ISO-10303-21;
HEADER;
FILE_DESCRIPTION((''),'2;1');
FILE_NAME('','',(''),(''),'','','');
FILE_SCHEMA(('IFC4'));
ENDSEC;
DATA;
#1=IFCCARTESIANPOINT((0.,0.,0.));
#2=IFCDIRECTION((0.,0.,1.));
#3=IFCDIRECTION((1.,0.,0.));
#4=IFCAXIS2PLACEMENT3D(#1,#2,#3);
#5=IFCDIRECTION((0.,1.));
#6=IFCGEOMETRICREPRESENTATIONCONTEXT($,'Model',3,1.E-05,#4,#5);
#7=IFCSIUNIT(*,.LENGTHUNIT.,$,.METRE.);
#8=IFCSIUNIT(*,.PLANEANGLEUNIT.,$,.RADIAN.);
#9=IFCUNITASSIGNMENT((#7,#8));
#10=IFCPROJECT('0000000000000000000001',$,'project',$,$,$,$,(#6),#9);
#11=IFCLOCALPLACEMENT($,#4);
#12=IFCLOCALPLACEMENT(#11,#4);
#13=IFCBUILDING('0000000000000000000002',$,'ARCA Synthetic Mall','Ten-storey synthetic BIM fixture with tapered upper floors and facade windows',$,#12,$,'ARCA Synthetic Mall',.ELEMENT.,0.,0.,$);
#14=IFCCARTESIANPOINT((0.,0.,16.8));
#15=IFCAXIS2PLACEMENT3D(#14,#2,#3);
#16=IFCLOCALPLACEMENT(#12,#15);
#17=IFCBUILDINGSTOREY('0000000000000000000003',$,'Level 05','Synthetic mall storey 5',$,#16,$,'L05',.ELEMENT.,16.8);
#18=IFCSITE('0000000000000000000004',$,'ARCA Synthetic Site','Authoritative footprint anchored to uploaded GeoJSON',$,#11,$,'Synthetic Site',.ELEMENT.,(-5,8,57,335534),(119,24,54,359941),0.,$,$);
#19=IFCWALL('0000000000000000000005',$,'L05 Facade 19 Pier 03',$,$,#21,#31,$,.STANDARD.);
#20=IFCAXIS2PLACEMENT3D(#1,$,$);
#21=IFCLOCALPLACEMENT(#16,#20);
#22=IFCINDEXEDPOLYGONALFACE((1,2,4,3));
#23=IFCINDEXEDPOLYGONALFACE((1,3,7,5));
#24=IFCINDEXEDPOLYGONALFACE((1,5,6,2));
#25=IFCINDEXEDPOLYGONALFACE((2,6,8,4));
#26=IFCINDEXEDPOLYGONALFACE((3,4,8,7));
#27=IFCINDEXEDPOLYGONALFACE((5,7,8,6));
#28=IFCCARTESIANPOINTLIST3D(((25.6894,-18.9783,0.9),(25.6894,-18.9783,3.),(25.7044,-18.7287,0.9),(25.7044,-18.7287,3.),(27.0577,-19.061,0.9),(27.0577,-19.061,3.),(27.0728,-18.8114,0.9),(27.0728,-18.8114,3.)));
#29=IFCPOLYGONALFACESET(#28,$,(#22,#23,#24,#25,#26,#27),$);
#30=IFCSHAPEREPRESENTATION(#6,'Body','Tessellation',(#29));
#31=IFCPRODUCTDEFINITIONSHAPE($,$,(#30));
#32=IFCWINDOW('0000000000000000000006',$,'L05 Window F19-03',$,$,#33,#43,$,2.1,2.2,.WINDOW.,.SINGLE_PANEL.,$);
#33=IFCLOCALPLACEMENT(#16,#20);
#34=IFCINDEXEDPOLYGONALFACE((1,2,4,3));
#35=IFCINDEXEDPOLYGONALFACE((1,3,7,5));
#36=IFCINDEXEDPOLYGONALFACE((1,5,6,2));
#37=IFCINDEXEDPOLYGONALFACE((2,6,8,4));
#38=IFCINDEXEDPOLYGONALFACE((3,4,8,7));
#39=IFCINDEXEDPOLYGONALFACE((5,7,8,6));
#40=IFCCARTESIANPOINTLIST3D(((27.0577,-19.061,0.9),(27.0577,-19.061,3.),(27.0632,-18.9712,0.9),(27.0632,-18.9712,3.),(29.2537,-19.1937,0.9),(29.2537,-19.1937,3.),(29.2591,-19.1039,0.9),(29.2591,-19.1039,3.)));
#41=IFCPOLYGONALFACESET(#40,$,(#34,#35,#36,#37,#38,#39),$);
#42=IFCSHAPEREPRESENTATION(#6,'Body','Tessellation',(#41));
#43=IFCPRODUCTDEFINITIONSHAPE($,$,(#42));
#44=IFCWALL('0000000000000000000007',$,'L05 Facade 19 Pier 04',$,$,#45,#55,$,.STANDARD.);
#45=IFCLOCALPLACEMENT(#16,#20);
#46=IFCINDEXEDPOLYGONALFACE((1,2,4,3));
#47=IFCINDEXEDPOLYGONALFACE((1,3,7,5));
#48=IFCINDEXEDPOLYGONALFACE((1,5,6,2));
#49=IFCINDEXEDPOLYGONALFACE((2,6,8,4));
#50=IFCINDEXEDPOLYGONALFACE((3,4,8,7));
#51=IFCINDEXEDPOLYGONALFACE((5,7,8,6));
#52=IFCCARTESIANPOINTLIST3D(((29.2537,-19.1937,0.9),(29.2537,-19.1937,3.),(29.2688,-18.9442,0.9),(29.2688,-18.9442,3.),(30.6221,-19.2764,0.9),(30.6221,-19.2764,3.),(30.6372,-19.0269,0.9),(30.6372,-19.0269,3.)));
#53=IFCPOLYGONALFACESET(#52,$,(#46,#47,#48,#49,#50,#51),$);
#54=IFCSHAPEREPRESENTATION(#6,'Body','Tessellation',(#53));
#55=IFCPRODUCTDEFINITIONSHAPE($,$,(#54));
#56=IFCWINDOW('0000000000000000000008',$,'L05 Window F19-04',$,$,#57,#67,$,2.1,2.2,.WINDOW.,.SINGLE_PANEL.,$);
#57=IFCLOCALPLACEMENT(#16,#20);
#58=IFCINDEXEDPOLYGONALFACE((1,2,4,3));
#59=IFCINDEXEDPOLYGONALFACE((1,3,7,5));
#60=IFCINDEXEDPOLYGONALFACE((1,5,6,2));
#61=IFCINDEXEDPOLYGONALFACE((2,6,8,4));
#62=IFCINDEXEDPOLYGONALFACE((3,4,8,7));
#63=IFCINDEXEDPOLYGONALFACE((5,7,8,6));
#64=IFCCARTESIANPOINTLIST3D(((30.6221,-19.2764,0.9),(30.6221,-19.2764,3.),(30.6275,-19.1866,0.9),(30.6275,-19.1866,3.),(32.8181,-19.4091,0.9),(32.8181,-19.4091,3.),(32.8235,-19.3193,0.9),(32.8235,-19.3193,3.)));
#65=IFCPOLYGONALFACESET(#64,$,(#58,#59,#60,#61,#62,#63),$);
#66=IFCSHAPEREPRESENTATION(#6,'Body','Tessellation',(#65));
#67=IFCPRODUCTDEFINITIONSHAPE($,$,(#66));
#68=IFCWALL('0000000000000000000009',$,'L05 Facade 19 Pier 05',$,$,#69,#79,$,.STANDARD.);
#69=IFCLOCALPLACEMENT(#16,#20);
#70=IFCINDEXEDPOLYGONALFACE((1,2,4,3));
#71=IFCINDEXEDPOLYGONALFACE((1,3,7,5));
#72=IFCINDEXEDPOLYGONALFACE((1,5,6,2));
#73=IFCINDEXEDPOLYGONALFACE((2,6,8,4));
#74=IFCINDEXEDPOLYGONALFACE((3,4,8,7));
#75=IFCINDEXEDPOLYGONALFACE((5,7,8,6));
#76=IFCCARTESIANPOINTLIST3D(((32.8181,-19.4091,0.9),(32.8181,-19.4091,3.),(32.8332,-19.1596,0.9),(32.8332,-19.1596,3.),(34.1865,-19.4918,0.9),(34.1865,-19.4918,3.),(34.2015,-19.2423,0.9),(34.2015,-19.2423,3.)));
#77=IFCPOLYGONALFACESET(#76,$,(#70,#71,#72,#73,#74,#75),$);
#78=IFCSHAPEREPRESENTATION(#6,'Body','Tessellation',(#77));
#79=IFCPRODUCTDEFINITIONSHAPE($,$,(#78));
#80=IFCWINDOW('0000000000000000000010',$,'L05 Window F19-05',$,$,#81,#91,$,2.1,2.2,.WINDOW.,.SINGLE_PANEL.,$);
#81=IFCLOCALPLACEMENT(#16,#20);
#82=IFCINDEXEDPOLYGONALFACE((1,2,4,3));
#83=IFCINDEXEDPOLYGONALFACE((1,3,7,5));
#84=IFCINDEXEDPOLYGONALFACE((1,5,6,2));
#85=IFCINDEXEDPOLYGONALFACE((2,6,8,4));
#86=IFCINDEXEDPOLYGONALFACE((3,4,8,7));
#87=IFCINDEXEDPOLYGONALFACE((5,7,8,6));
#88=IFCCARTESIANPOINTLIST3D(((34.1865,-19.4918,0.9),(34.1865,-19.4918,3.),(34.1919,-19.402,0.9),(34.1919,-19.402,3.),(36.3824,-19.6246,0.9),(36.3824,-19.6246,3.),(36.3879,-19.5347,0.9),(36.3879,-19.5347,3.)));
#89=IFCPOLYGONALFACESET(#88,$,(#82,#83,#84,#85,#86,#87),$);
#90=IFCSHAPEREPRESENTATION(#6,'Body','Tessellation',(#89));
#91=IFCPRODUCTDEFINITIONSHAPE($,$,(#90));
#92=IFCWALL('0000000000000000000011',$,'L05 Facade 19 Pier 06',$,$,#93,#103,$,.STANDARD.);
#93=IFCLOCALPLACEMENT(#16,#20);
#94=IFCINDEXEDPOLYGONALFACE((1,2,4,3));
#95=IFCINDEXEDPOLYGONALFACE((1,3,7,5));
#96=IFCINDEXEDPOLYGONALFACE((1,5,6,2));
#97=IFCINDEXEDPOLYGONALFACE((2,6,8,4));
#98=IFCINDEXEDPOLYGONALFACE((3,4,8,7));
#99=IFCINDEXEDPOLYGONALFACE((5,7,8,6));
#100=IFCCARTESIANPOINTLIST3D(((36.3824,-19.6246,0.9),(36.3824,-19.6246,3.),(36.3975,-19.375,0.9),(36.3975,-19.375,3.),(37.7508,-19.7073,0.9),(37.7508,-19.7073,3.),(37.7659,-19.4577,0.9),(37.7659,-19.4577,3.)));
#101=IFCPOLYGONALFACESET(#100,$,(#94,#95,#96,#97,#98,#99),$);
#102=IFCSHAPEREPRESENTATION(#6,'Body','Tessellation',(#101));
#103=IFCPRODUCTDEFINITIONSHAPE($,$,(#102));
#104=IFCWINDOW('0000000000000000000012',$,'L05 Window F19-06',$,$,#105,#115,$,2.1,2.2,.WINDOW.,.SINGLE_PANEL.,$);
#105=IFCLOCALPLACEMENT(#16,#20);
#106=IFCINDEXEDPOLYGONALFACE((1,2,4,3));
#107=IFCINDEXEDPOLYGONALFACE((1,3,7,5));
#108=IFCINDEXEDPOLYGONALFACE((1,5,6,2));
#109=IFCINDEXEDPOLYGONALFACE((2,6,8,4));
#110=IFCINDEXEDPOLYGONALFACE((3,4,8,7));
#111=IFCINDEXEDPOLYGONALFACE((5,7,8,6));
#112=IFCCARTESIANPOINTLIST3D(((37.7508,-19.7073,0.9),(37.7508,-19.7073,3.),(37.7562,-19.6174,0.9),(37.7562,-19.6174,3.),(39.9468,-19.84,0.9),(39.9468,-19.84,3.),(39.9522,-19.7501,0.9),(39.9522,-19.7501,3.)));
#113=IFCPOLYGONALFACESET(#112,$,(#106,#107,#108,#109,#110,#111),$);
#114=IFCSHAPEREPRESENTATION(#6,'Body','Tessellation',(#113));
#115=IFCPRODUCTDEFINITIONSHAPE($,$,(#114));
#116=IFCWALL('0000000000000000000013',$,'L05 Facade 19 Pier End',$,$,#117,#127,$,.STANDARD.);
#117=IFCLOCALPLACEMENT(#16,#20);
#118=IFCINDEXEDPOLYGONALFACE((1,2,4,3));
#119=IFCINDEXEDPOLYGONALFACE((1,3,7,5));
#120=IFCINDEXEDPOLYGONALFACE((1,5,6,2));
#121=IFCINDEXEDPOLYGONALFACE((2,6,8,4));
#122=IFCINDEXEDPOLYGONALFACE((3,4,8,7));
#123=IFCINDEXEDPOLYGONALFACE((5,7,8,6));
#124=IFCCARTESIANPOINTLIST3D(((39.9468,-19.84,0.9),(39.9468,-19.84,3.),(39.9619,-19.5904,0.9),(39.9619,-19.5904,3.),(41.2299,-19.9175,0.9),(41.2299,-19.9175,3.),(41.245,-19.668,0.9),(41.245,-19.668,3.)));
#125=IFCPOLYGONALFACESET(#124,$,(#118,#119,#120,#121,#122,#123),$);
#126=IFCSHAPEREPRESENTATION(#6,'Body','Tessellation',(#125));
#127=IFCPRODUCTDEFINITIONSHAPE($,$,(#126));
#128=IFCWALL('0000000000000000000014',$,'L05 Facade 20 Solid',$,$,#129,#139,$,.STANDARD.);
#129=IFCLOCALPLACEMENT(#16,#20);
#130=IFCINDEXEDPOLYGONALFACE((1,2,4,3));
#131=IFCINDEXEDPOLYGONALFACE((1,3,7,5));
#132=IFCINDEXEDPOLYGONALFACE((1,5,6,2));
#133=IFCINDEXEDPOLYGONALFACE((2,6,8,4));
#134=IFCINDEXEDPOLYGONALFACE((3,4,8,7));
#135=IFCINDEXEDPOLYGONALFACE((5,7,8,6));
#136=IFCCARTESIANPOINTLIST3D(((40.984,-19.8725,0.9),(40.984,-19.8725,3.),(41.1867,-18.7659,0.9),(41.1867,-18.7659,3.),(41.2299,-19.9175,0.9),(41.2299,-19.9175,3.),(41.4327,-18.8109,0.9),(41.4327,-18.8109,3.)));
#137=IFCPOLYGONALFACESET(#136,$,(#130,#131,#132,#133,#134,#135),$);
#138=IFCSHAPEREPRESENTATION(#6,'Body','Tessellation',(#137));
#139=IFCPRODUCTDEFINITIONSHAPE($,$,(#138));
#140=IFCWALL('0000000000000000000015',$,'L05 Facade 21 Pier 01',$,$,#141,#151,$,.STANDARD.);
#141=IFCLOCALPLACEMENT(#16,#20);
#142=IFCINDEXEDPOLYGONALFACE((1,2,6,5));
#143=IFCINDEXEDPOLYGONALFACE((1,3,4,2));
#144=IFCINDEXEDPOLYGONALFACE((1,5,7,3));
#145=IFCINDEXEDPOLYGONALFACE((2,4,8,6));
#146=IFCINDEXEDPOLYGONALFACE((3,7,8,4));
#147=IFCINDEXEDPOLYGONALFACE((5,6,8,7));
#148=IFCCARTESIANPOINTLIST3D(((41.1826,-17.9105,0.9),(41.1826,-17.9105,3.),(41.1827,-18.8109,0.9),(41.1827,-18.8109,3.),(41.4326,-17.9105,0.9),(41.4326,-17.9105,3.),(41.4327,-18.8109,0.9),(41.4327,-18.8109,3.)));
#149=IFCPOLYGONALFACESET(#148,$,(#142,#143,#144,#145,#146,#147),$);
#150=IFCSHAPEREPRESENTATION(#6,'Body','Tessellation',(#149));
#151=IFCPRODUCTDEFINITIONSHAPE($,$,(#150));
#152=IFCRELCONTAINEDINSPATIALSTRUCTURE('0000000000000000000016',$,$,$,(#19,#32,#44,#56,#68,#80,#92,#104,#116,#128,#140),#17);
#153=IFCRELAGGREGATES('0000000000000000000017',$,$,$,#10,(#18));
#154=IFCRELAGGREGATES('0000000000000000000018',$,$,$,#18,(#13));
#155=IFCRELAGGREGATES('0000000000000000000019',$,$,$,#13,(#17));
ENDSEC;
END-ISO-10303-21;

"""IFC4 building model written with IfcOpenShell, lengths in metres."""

from ifc_helpers import new_model, si_unit, direction, frame, origin_with_axes, place, context, project, spatial, polyline, outline, extrude, element, save


model = new_model("IFC4")

# Units and contexts
model_context = context("Model", 3, precision=1e-05, world=origin_with_axes(), true_north=direction((0.0, 1.0)))
ifc_project = project(units=[si_unit("LENGTHUNIT", "METRE"), si_unit("PLANEANGLEUNIT", "RADIAN")], contexts=[model_context])

# Site, building, storey
site_placement = place(None, origin_with_axes())
site = spatial("IfcSite", under=ifc_project, at=site_placement, Name="ARCA Synthetic Site", Description="Authoritative footprint anchored to uploaded GeoJSON", LongName="Synthetic Site", CompositionType="ELEMENT", RefLatitude=(-5, 8, 57, 335534), RefLongitude=(119, 24, 54, 359941), RefElevation=0.0)
building_placement = place(site_placement, origin_with_axes())
building = spatial("IfcBuilding", under=site, at=building_placement, Name="ARCA Synthetic Mall", Description="Ten-storey synthetic BIM fixture with tapered upper floors and facade windows", LongName="ARCA Synthetic Mall", CompositionType="ELEMENT", ElevationOfRefHeight=0.0, ElevationOfTerrain=0.0)
storey_placement = place(building_placement, frame((0.0, 0.0, 16.8), z_axis=(0.0, 0.0, 1.0), x_axis=(1.0, 0.0, 0.0)))
storey = spatial("IfcBuildingStorey", under=building, at=storey_placement, Name="Level 05", Description="Synthetic mall storey 5", LongName="L05", CompositionType="ELEMENT", Elevation=16.8)

# Wall
wall_1_placement = place(storey_placement, frame((0.0, 0.0, 0.9), z_axis=(0.0, 0.0, 1.0), x_axis=(1.0, 0.0, 0.0)))
element("IfcWall", 1, at=wall_1_placement, inside=storey, Name="L05 Facade 19 Pier 03", PredefinedType="STANDARD", context=model_context, shape_type="SweptSolid", body=[
    extrude(outline(polyline([(25.6894, -18.9783), (27.0577, -19.061), (27.0728, -18.8114), (25.7044, -18.7287), (25.6894, -18.9783)])), origin_with_axes(), (0.0, 0.0, 1.0), 2.1),
])

# Window
window_1_placement = place(storey_placement, frame((0.0, 0.0, 0.9), z_axis=(0.0, 0.0, 1.0), x_axis=(1.0, 0.0, 0.0)))
element("IfcWindow", 2, at=window_1_placement, inside=storey, Name="L05 Window F19-03", OverallHeight=2.1, OverallWidth=2.2, PartitioningType="SINGLE_PANEL", PredefinedType="WINDOW", context=model_context, shape_type="SweptSolid", body=[
    extrude(outline(polyline([(27.0577, -19.061), (29.2537, -19.1937), (29.2591, -19.1039), (27.0632, -18.9712), (27.0577, -19.061)])), origin_with_axes(), (0.0, 0.0, 1.0), 2.1),
])

# Wall
wall_2_placement = place(storey_placement, frame((0.0, 0.0, 0.9), z_axis=(0.0, 0.0, 1.0), x_axis=(1.0, 0.0, 0.0)))
element("IfcWall", 3, at=wall_2_placement, inside=storey, Name="L05 Facade 19 Pier 04", PredefinedType="STANDARD", context=model_context, shape_type="SweptSolid", body=[
    extrude(outline(polyline([(29.2537, -19.1937), (30.6221, -19.2764), (30.6372, -19.0269), (29.2688, -18.9442), (29.2537, -19.1937)])), origin_with_axes(), (0.0, 0.0, 1.0), 2.1),
])

# Window
window_2_placement = place(storey_placement, frame((0.0, 0.0, 0.9), z_axis=(0.0, 0.0, 1.0), x_axis=(1.0, 0.0, 0.0)))
element("IfcWindow", 4, at=window_2_placement, inside=storey, Name="L05 Window F19-04", OverallHeight=2.1, OverallWidth=2.2, PartitioningType="SINGLE_PANEL", PredefinedType="WINDOW", context=model_context, shape_type="SweptSolid", body=[
    extrude(outline(polyline([(30.6221, -19.2764), (32.8181, -19.4091), (32.8235, -19.3193), (30.6275, -19.1866), (30.6221, -19.2764)])), origin_with_axes(), (0.0, 0.0, 1.0), 2.1),
])

# Wall
wall_3_placement = place(storey_placement, frame((0.0, 0.0, 0.9), z_axis=(0.0, 0.0, 1.0), x_axis=(1.0, 0.0, 0.0)))
element("IfcWall", 5, at=wall_3_placement, inside=storey, Name="L05 Facade 19 Pier 05", PredefinedType="STANDARD", context=model_context, shape_type="SweptSolid", body=[
    extrude(outline(polyline([(32.8181, -19.4091), (34.1865, -19.4918), (34.2015, -19.2423), (32.8332, -19.1596), (32.8181, -19.4091)])), origin_with_axes(), (0.0, 0.0, 1.0), 2.1),
])

# Window
window_3_placement = place(storey_placement, frame((0.0, 0.0, 0.9), z_axis=(0.0, 0.0, 1.0), x_axis=(1.0, 0.0, 0.0)))
element("IfcWindow", 6, at=window_3_placement, inside=storey, Name="L05 Window F19-05", OverallHeight=2.1, OverallWidth=2.2, PartitioningType="SINGLE_PANEL", PredefinedType="WINDOW", context=model_context, shape_type="SweptSolid", body=[
    extrude(outline(polyline([(34.1865, -19.4918), (36.3824, -19.6245), (36.3879, -19.5347), (34.1919, -19.402), (34.1865, -19.4918)])), origin_with_axes(), (0.0, 0.0, 1.0), 2.1),
])

# Wall
wall_4_placement = place(storey_placement, frame((0.0, 0.0, 0.9), z_axis=(0.0, 0.0, 1.0), x_axis=(1.0, 0.0, 0.0)))
element("IfcWall", 7, at=wall_4_placement, inside=storey, Name="L05 Facade 19 Pier 06", PredefinedType="STANDARD", context=model_context, shape_type="SweptSolid", body=[
    extrude(outline(polyline([(36.3824, -19.6245), (37.7508, -19.7073), (37.7659, -19.4577), (36.3975, -19.375), (36.3824, -19.6245)])), origin_with_axes(), (0.0, 0.0, 1.0), 2.1),
])

# Window
window_4_placement = place(storey_placement, frame((0.0, 0.0, 0.9), z_axis=(0.0, 0.0, 1.0), x_axis=(1.0, 0.0, 0.0)))
element("IfcWindow", 8, at=window_4_placement, inside=storey, Name="L05 Window F19-06", OverallHeight=2.1, OverallWidth=2.2, PartitioningType="SINGLE_PANEL", PredefinedType="WINDOW", context=model_context, shape_type="SweptSolid", body=[
    extrude(outline(polyline([(37.7508, -19.7073), (39.9468, -19.84), (39.9522, -19.7501), (37.7562, -19.6174), (37.7508, -19.7073)])), origin_with_axes(), (0.0, 0.0, 1.0), 2.1),
])

# Walls
wall_5_placement = place(storey_placement, frame((0.0, 0.0, 0.9), z_axis=(0.0, 0.0, 1.0), x_axis=(1.0, 0.0, 0.0)))
element("IfcWall", 9, at=wall_5_placement, inside=storey, Name="L05 Facade 19 Pier End", PredefinedType="STANDARD", context=model_context, shape_type="SweptSolid", body=[
    extrude(outline(polyline([(39.9468, -19.84), (41.2299, -19.9175), (41.245, -19.668), (39.9619, -19.5904), (39.9468, -19.84)])), origin_with_axes(), (0.0, 0.0, 1.0), 2.1),
])
wall_6_placement = place(storey_placement, frame((0.0, 0.0, 0.9), z_axis=(0.0, 0.0, 1.0), x_axis=(1.0, 0.0, 0.0)))
element("IfcWall", 10, at=wall_6_placement, inside=storey, Name="L05 Facade 20 Solid", PredefinedType="STANDARD", context=model_context, shape_type="SweptSolid", body=[
    extrude(outline(polyline([(41.2299, -19.9175), (41.4327, -18.8109), (41.1867, -18.7659), (40.984, -19.8725), (41.2299, -19.9175)])), origin_with_axes(), (0.0, 0.0, 1.0), 2.1),
])
wall_7_placement = place(storey_placement, frame((0.0, 0.0, 0.9), z_axis=(0.0, 0.0, 1.0), x_axis=(1.0, 0.0, 0.0)))
element("IfcWall", 11, at=wall_7_placement, inside=storey, Name="L05 Facade 21 Pier 01", PredefinedType="STANDARD", context=model_context, shape_type="SweptSolid", body=[
    extrude(outline(polyline([(41.4327, -18.8109), (41.4326, -17.9105), (41.1826, -17.9105), (41.1827, -18.8109), (41.4327, -18.8109)])), origin_with_axes(), (0.0, 0.0, 1.0), 2.1),
])

save(model, "model.ifc")
